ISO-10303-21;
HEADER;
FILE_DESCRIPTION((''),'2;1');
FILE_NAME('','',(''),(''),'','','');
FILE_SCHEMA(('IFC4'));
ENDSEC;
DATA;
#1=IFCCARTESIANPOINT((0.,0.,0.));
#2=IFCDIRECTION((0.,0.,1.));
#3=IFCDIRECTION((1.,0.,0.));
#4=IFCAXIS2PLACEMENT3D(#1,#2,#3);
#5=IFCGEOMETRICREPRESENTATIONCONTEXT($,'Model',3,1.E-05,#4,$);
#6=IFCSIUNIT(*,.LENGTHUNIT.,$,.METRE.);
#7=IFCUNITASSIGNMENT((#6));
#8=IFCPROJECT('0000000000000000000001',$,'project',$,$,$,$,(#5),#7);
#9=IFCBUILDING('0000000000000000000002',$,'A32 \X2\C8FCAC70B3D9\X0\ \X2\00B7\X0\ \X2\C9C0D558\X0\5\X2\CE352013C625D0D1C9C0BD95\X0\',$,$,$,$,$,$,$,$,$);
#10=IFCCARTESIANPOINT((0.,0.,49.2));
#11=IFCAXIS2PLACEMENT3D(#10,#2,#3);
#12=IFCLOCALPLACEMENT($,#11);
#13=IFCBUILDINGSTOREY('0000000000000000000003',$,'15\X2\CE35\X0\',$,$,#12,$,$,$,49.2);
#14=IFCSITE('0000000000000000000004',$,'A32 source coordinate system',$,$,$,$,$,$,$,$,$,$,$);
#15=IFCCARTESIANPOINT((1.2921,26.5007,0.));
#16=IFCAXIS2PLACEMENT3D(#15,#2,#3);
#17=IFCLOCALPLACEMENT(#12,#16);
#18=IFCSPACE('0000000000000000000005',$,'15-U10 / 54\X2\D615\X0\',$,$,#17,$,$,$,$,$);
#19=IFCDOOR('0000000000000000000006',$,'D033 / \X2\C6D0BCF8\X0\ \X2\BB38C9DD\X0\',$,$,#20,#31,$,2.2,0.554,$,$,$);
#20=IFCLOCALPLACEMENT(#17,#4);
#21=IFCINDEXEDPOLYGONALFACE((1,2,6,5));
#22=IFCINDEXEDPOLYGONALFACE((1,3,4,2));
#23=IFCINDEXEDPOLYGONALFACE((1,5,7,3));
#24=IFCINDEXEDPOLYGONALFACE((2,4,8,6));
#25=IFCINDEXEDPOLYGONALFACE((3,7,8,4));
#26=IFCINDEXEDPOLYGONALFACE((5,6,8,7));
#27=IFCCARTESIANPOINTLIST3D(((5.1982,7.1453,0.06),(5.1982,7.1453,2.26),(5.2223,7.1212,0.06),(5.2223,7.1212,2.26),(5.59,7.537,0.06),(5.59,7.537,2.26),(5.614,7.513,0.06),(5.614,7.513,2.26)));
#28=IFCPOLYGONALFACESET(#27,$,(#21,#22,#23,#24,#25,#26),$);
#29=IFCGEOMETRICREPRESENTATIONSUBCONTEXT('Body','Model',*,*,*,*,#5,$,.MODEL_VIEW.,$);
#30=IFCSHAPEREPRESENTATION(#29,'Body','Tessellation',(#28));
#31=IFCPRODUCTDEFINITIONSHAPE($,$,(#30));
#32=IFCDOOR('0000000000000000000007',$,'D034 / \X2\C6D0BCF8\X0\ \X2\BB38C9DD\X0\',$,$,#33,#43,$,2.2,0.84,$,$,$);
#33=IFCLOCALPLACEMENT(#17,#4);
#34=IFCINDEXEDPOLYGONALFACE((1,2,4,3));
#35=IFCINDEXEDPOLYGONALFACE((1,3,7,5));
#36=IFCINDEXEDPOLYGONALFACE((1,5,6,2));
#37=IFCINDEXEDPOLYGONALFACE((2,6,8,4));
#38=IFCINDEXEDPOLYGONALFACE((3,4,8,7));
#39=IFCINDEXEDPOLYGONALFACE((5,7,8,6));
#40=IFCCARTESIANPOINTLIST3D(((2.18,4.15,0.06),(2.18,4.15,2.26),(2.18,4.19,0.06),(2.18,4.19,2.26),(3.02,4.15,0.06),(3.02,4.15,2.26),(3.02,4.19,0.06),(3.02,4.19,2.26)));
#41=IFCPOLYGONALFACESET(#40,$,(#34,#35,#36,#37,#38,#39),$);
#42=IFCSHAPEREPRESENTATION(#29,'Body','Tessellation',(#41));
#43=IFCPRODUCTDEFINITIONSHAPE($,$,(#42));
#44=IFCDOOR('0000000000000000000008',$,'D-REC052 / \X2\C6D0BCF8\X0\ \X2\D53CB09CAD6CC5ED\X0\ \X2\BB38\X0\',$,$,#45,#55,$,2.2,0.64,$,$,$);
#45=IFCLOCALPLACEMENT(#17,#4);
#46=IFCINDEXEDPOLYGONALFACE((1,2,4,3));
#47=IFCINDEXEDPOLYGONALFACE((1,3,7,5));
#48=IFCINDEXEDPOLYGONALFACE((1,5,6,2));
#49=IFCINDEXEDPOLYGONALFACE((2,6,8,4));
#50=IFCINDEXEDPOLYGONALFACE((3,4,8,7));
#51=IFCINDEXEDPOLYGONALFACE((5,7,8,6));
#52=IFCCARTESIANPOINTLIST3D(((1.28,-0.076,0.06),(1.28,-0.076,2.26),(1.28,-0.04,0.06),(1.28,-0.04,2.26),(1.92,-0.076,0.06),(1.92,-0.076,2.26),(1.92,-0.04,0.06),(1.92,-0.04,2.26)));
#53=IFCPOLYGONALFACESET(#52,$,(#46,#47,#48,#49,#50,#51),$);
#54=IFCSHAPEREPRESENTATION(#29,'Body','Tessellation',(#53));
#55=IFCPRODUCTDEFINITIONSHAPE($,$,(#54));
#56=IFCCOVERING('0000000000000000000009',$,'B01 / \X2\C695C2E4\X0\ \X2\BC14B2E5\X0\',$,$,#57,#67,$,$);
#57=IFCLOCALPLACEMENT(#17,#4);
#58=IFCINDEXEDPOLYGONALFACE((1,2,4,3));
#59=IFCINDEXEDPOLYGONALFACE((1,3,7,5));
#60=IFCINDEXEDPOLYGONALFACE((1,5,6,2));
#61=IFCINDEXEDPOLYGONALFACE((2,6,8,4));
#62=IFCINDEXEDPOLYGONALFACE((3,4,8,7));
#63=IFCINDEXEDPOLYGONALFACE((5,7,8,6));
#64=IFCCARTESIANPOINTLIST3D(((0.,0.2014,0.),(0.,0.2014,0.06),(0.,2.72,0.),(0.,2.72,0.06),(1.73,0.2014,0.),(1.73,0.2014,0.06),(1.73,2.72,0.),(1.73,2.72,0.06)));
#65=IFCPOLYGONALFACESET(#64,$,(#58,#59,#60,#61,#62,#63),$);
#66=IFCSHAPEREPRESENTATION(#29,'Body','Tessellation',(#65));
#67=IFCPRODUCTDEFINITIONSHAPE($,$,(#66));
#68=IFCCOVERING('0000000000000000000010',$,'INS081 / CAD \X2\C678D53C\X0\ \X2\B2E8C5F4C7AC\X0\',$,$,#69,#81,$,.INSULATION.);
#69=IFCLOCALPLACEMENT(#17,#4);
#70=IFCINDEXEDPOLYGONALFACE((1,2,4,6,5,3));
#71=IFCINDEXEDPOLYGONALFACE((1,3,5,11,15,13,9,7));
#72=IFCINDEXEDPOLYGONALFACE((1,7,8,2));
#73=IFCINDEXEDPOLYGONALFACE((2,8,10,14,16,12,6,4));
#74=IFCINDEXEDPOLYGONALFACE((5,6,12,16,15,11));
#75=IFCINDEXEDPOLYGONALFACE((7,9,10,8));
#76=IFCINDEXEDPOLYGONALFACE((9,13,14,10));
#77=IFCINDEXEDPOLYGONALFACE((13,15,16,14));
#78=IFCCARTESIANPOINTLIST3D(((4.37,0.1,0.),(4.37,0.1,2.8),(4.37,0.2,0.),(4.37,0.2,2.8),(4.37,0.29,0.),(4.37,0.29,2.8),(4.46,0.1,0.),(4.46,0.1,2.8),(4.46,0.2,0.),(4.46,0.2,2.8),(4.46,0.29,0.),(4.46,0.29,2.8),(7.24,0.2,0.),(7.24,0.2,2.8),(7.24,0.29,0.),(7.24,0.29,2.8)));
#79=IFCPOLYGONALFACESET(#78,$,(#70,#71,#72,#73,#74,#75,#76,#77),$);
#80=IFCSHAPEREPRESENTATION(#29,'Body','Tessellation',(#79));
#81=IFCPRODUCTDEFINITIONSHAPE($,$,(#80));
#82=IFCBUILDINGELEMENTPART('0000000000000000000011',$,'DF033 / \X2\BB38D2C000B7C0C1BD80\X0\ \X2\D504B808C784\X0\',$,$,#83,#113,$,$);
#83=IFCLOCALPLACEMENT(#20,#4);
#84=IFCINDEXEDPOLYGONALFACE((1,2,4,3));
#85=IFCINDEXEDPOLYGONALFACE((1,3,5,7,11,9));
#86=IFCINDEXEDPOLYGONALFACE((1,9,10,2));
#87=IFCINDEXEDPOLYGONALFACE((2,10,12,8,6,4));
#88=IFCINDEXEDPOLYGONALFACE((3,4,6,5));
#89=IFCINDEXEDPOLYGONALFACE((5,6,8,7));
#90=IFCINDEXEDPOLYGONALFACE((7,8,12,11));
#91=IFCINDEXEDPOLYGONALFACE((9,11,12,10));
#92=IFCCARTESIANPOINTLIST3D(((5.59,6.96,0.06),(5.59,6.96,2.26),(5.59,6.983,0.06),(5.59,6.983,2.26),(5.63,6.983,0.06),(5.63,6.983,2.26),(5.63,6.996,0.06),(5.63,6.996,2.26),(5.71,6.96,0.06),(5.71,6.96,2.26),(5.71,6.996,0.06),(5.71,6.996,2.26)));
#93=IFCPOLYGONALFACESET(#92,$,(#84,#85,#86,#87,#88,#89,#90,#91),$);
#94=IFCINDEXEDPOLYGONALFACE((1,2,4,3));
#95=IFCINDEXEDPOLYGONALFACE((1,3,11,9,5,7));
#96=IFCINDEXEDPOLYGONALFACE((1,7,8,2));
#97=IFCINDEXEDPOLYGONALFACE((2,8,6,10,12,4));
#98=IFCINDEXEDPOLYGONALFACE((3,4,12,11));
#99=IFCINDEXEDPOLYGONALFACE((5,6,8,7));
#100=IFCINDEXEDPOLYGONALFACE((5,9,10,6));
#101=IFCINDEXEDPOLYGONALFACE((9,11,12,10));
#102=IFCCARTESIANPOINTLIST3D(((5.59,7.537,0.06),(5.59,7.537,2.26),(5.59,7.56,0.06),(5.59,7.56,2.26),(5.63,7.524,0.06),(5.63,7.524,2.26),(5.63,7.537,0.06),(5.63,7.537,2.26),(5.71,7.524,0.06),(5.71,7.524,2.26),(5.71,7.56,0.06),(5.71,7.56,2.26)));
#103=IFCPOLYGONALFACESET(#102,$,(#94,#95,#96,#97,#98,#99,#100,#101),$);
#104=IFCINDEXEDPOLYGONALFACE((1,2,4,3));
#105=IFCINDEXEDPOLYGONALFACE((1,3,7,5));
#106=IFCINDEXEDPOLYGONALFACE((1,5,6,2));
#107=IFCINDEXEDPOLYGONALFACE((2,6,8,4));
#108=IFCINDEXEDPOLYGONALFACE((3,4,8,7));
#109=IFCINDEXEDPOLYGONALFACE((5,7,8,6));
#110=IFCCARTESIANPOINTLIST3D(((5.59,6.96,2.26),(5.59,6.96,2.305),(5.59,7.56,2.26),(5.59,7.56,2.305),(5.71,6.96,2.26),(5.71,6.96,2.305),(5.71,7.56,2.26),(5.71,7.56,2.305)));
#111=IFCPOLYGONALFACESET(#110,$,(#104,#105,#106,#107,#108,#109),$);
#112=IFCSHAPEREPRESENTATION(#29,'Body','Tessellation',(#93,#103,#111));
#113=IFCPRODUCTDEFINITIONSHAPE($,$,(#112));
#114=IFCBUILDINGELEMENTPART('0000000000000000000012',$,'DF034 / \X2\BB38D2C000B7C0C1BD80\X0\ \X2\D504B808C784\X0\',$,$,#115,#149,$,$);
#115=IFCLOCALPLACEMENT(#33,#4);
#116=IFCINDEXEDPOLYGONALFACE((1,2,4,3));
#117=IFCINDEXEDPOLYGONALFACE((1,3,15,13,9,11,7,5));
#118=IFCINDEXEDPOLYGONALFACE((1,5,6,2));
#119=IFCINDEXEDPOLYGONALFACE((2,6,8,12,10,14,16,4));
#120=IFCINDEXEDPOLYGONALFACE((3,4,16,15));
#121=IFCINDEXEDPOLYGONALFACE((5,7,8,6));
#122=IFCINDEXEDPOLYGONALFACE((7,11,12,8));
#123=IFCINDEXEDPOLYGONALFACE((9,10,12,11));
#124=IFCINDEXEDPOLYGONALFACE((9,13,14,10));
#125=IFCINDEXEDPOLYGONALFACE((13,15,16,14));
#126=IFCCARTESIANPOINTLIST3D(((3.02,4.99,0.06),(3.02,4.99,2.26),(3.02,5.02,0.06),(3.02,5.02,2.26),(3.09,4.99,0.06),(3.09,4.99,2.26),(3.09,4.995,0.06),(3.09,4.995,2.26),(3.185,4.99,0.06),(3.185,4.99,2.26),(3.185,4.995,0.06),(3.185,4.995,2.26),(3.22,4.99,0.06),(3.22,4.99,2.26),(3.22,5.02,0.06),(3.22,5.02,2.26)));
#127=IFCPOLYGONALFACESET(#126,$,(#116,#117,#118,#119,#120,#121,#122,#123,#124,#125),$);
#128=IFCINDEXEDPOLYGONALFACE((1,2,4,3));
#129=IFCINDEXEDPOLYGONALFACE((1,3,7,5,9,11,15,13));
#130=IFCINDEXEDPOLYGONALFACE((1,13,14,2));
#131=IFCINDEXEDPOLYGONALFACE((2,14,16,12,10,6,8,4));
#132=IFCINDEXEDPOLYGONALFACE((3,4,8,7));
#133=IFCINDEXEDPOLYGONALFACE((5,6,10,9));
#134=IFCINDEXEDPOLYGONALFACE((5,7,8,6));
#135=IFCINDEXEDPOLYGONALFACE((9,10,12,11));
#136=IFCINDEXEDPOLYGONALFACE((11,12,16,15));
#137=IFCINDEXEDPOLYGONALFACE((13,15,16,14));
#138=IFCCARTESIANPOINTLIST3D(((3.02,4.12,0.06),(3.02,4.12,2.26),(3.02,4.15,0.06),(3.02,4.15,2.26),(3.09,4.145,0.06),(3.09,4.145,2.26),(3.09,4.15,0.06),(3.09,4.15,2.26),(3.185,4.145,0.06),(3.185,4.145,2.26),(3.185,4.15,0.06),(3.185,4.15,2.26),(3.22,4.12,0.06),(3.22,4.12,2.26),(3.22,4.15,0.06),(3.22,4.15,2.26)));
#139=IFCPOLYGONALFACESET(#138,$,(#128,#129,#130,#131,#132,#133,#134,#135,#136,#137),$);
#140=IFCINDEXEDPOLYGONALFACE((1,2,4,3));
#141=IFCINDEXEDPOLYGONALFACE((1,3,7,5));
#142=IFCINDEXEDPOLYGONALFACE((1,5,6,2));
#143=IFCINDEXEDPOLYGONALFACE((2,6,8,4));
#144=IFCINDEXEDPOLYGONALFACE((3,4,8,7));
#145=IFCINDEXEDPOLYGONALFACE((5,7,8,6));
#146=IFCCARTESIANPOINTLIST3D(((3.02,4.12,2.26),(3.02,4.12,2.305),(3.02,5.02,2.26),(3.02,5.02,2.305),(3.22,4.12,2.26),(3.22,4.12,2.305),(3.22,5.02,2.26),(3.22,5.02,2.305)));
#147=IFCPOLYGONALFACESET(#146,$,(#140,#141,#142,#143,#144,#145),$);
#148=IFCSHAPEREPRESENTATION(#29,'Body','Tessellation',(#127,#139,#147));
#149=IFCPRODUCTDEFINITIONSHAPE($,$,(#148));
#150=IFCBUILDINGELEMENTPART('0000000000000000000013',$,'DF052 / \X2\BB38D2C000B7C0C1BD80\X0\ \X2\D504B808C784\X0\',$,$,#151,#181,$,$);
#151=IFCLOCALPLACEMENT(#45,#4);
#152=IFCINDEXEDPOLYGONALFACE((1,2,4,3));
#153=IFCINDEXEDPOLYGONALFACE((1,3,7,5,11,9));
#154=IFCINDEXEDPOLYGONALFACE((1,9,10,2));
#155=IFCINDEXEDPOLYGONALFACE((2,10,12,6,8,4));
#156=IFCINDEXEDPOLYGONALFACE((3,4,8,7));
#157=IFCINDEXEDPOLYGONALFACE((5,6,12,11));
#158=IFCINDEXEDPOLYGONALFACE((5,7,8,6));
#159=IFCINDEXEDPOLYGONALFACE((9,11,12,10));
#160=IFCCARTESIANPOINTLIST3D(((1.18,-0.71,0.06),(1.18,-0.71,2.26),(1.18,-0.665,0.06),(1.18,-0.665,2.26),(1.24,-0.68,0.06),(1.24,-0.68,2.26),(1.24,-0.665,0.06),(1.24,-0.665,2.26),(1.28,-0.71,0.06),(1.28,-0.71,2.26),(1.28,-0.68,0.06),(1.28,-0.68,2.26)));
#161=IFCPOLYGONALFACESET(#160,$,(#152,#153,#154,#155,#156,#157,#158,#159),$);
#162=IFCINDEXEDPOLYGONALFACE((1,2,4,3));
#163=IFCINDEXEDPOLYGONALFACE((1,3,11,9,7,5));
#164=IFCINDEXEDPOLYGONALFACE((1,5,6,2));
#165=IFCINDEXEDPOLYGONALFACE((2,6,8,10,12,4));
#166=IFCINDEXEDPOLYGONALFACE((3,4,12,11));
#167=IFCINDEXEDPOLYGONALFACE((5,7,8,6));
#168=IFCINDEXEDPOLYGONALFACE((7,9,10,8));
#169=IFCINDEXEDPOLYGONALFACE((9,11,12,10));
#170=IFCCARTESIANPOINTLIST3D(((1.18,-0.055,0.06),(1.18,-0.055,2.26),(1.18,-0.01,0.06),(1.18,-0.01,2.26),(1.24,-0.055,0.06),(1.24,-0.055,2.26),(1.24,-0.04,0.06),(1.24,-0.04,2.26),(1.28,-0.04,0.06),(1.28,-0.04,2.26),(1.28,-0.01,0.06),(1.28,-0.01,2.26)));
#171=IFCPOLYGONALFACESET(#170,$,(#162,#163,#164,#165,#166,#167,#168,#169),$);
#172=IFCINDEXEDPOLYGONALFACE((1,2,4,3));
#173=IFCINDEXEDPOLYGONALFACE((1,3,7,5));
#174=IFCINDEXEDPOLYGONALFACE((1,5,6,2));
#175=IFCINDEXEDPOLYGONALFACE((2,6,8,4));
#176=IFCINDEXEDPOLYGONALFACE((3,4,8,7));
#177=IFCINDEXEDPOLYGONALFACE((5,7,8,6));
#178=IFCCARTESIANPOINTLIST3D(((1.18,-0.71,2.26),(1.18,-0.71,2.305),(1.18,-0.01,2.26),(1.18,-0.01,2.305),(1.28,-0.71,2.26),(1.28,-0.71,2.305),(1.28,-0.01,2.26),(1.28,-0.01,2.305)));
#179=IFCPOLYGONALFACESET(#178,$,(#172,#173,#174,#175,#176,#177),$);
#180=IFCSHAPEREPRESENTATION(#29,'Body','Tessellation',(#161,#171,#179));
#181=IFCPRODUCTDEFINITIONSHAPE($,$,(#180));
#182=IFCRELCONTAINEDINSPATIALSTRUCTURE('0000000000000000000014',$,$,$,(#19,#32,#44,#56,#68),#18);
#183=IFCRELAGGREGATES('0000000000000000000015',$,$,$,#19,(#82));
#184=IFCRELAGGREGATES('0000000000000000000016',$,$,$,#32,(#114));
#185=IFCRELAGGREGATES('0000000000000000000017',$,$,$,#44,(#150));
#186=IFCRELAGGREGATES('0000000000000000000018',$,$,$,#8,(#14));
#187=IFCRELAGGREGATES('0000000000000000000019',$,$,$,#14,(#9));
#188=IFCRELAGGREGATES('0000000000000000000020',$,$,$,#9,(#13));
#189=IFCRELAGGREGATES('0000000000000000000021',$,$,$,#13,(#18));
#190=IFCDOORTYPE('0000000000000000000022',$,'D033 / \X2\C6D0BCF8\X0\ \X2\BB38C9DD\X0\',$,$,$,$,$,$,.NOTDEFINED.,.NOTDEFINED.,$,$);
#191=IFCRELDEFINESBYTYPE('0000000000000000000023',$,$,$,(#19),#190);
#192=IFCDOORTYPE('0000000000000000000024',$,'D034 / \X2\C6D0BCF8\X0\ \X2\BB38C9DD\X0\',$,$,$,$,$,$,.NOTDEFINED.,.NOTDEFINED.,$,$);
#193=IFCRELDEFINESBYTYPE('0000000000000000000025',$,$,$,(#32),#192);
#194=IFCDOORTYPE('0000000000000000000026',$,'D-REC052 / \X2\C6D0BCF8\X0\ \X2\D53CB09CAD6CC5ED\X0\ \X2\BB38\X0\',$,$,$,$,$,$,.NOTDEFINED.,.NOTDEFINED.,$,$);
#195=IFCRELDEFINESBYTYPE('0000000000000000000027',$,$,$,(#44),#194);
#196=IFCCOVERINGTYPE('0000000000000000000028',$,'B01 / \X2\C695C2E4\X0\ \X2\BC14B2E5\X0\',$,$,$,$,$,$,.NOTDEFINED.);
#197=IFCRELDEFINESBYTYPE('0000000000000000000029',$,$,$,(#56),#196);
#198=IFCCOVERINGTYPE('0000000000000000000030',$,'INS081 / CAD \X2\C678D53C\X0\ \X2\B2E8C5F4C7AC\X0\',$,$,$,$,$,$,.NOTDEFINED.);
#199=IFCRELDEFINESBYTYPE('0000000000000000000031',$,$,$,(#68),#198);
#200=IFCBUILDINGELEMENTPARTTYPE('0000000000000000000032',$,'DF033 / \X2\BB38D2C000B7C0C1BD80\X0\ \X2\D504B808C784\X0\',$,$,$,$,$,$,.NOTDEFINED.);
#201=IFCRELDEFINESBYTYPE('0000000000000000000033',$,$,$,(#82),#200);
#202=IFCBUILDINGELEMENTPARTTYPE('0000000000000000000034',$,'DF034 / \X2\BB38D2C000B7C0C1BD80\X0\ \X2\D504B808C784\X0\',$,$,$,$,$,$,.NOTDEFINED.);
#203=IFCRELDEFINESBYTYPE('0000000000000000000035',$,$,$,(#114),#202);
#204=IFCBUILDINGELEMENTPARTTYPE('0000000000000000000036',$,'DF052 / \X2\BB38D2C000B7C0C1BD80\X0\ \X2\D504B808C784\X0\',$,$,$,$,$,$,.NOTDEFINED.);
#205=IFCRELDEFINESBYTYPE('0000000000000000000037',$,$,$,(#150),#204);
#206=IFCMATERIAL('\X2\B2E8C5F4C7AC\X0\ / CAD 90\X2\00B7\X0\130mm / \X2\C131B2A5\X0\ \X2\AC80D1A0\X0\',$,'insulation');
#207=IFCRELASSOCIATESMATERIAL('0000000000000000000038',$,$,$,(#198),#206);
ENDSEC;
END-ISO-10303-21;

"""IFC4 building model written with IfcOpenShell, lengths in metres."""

from ifc_helpers import new_model, si_unit, frame, origin, origin_with_axes, place, context, subcontext, project, spatial, polyline, outline, extrude, source, transform, mapped, material, type_object, type_shapes, element, aggregate, save


model = new_model("IFC4")

# Units and contexts
model_context = context("Model", 3, precision=1e-05, world=origin_with_axes())
body_context = subcontext(model_context, "Body", "Model", "MODEL_VIEW")
ifc_project = project(units=[si_unit("LENGTHUNIT", "METRE")], contexts=[model_context])

# Site, building, storey, space
storey_placement = place(None, frame((0.0, 0.0, 49.2), z_axis=(0.0, 0.0, 1.0), x_axis=(1.0, 0.0, 0.0)))
space_placement = place(storey_placement, frame((1.2921, 26.5007, 0.0), z_axis=(0.0, 0.0, 1.0), x_axis=(1.0, 0.0, 0.0)))
site = spatial("IfcSite", under=ifc_project, Name="A32 source coordinate system")
building = spatial("IfcBuilding", under=site, Name="A32 주거동 · 지하5층–옥탑지붕")
storey = spatial("IfcBuildingStorey", under=building, at=storey_placement, Name="15층", Elevation=49.2)
space = spatial("IfcSpace", under=storey, at=space_placement, Name="15-U10 / 54형")

# Doors
door_type_1 = type_object("IfcDoorType", Name="D033 / 원본 문짝", OperationType="NOTDEFINED", PredefinedType="NOTDEFINED")
shared_shape_1 = source(origin(), body_context, "Body", "SweptSolid", [
    extrude(outline(polyline([(5.2223, 7.1212), (5.1982, 7.1453), (5.59, 7.537), (5.614, 7.513), (5.2223, 7.1212)])), frame((0.0, 0.0, 0.06)), (0.0, 0.0, 1.0), 2.2),
])
type_shapes(door_type_1, [shared_shape_1])
door_1_placement = place(space_placement, origin_with_axes())
door_1 = element("IfcDoor", 1, at=door_1_placement, inside=space, type_object=door_type_1, Name="D033 / 원본 문짝", OverallHeight=2.2, OverallWidth=0.554, context=body_context, shape_type="MappedRepresentation", body=[
    mapped(shared_shape_1, transform((0.0, 0.0, 0.0), scale=1.0)),
])
door_type_2 = type_object("IfcDoorType", Name="D034 / 원본 문짝", OperationType="NOTDEFINED", PredefinedType="NOTDEFINED")
shared_shape_2 = source(origin(), body_context, "Body", "SweptSolid", [
    extrude(outline(polyline([(3.02, 4.15), (2.18, 4.15), (2.18, 4.19), (3.02, 4.19), (3.02, 4.15)])), frame((0.0, 0.0, 0.06)), (0.0, 0.0, 1.0), 2.2),
])
type_shapes(door_type_2, [shared_shape_2])
door_2_placement = place(space_placement, origin_with_axes())
door_2 = element("IfcDoor", 2, at=door_2_placement, inside=space, type_object=door_type_2, Name="D034 / 원본 문짝", OverallHeight=2.2, OverallWidth=0.84, context=body_context, shape_type="MappedRepresentation", body=[
    mapped(shared_shape_2, transform((0.0, 0.0, 0.0), scale=1.0)),
])
door_type_3 = type_object("IfcDoorType", Name="D-REC052 / 원본 피난구역 문", OperationType="NOTDEFINED", PredefinedType="NOTDEFINED")
shared_shape_3 = source(origin(), body_context, "Body", "SweptSolid", [
    extrude(outline(polyline([(1.92, -0.076), (1.28, -0.076), (1.28, -0.04), (1.92, -0.04), (1.92, -0.076)])), frame((0.0, 0.0, 0.06)), (0.0, 0.0, 1.0), 2.2),
])
type_shapes(door_type_3, [shared_shape_3])
door_3_placement = place(space_placement, origin_with_axes())
door_3 = element("IfcDoor", 3, at=door_3_placement, inside=space, type_object=door_type_3, Name="D-REC052 / 원본 피난구역 문", OverallHeight=2.2, OverallWidth=0.64, context=body_context, shape_type="MappedRepresentation", body=[
    mapped(shared_shape_3, transform((0.0, 0.0, 0.0), scale=1.0)),
])

# Coverings
covering_type_1 = type_object("IfcCoveringType", Name="B01 / 욕실 바닥", PredefinedType="NOTDEFINED")
shared_shape_4 = source(origin(), body_context, "Body", "SweptSolid", [
    extrude(outline(polyline([(0.0, 0.2014), (0.0, 2.72), (1.73, 2.72), (1.73, 0.2014), (0.0, 0.2014)])), origin(), (0.0, 0.0, 1.0), 0.06),
])
type_shapes(covering_type_1, [shared_shape_4])
covering_1_placement = place(space_placement, origin_with_axes())
element("IfcCovering", 4, at=covering_1_placement, inside=space, type_object=covering_type_1, Name="B01 / 욕실 바닥", context=body_context, shape_type="MappedRepresentation", body=[
    mapped(shared_shape_4, transform((0.0, 0.0, 0.0), scale=1.0)),
])
ifc_material = material(Name="단열재 / CAD 90·130mm / 성능 검토", Category="insulation")
covering_type_2 = type_object("IfcCoveringType", Name="INS081 / CAD 외피 단열재", PredefinedType="NOTDEFINED", material=ifc_material)
shared_shape_5 = source(origin(), body_context, "Body", "SweptSolid", [
    extrude(outline(polyline([(4.37, 0.2), (4.37, 0.29), (4.46, 0.29), (7.24, 0.29), (7.24, 0.2), (4.46, 0.2), (4.46, 0.1), (4.37, 0.1), (4.37, 0.2)])), origin(), (0.0, 0.0, 1.0), 2.8),
])
type_shapes(covering_type_2, [shared_shape_5])
covering_2_placement = place(space_placement, origin_with_axes())
element("IfcCovering", 5, at=covering_2_placement, inside=space, type_object=covering_type_2, Name="INS081 / CAD 외피 단열재", PredefinedType="INSULATION", context=body_context, shape_type="MappedRepresentation", body=[
    mapped(shared_shape_5, transform((0.0, 0.0, 0.0), scale=1.0)),
])

# Building element parts
building_element_part_type_1 = type_object("IfcBuildingElementPartType", Name="DF033 / 문틀·상부 프레임", PredefinedType="NOTDEFINED")
shared_shape_6 = source(origin(), body_context, "Body", "SweptSolid", [
    extrude(outline(polyline([(5.59, 6.96), (5.59, 6.983), (5.63, 6.983), (5.63, 6.996), (5.71, 6.996), (5.71, 6.96), (5.59, 6.96)])), frame((0.0, 0.0, 0.06)), (0.0, 0.0, 1.0), 2.2),
    extrude(outline(polyline([(5.71, 7.524), (5.63, 7.524), (5.63, 7.537), (5.59, 7.537), (5.59, 7.56), (5.71, 7.56), (5.71, 7.524)])), frame((0.0, 0.0, 0.06)), (0.0, 0.0, 1.0), 2.2),
    extrude(outline(polyline([(5.59, 6.96), (5.59, 7.56), (5.71, 7.56), (5.71, 6.96), (5.59, 6.96)])), frame((0.0, 0.0, 2.26)), (0.0, 0.0, 1.0), 0.045),
])
type_shapes(building_element_part_type_1, [shared_shape_6])
building_element_part_1_placement = place(door_1_placement, origin_with_axes())
building_element_part_1 = element("IfcBuildingElementPart", 6, at=building_element_part_1_placement, type_object=building_element_part_type_1, Name="DF033 / 문틀·상부 프레임", context=body_context, shape_type="MappedRepresentation", body=[
    mapped(shared_shape_6, transform((0.0, 0.0, 0.0), scale=1.0)),
])
aggregate(door_1, [building_element_part_1])
building_element_part_type_2 = type_object("IfcBuildingElementPartType", Name="DF034 / 문틀·상부 프레임", PredefinedType="NOTDEFINED")
shared_shape_7 = source(origin(), body_context, "Body", "SweptSolid", [
    extrude(outline(polyline([(3.22, 5.02), (3.22, 4.99), (3.185, 4.99), (3.185, 4.995), (3.09, 4.995), (3.09, 4.99), (3.02, 4.99), (3.02, 5.02), (3.22, 5.02)])), frame((0.0, 0.0, 0.06)), (0.0, 0.0, 1.0), 2.2),
    extrude(outline(polyline([(3.02, 4.15), (3.09, 4.15), (3.09, 4.145), (3.185, 4.145), (3.185, 4.15), (3.22, 4.15), (3.22, 4.12), (3.02, 4.12), (3.02, 4.15)])), frame((0.0, 0.0, 0.06)), (0.0, 0.0, 1.0), 2.2),
    extrude(outline(polyline([(3.02, 4.12), (3.02, 5.02), (3.22, 5.02), (3.22, 4.12), (3.02, 4.12)])), frame((0.0, 0.0, 2.26)), (0.0, 0.0, 1.0), 0.045),
])
type_shapes(building_element_part_type_2, [shared_shape_7])
building_element_part_2_placement = place(door_2_placement, origin_with_axes())
building_element_part_2 = element("IfcBuildingElementPart", 7, at=building_element_part_2_placement, type_object=building_element_part_type_2, Name="DF034 / 문틀·상부 프레임", context=body_context, shape_type="MappedRepresentation", body=[
    mapped(shared_shape_7, transform((0.0, 0.0, 0.0), scale=1.0)),
])
aggregate(door_2, [building_element_part_2])
building_element_part_type_3 = type_object("IfcBuildingElementPartType", Name="DF052 / 문틀·상부 프레임", PredefinedType="NOTDEFINED")
shared_shape_8 = source(origin(), body_context, "Body", "SweptSolid", [
    extrude(outline(polyline([(1.18, -0.71), (1.18, -0.665), (1.24, -0.665), (1.24, -0.68), (1.28, -0.68), (1.28, -0.71), (1.18, -0.71)])), frame((0.0, 0.0, 0.06)), (0.0, 0.0, 1.0), 2.2),
    extrude(outline(polyline([(1.28, -0.04), (1.24, -0.04), (1.24, -0.055), (1.18, -0.055), (1.18, -0.01), (1.28, -0.01), (1.28, -0.04)])), frame((0.0, 0.0, 0.06)), (0.0, 0.0, 1.0), 2.2),
    extrude(outline(polyline([(1.18, -0.71), (1.18, -0.01), (1.28, -0.01), (1.28, -0.71), (1.18, -0.71)])), frame((0.0, 0.0, 2.26)), (0.0, 0.0, 1.0), 0.045),
])
type_shapes(building_element_part_type_3, [shared_shape_8])
building_element_part_3_placement = place(door_3_placement, origin_with_axes())
building_element_part_3 = element("IfcBuildingElementPart", 8, at=building_element_part_3_placement, type_object=building_element_part_type_3, Name="DF052 / 문틀·상부 프레임", context=body_context, shape_type="MappedRepresentation", body=[
    mapped(shared_shape_8, transform((0.0, 0.0, 0.0), scale=1.0)),
])
aggregate(door_3, [building_element_part_3])

save(model, "model.ifc")
